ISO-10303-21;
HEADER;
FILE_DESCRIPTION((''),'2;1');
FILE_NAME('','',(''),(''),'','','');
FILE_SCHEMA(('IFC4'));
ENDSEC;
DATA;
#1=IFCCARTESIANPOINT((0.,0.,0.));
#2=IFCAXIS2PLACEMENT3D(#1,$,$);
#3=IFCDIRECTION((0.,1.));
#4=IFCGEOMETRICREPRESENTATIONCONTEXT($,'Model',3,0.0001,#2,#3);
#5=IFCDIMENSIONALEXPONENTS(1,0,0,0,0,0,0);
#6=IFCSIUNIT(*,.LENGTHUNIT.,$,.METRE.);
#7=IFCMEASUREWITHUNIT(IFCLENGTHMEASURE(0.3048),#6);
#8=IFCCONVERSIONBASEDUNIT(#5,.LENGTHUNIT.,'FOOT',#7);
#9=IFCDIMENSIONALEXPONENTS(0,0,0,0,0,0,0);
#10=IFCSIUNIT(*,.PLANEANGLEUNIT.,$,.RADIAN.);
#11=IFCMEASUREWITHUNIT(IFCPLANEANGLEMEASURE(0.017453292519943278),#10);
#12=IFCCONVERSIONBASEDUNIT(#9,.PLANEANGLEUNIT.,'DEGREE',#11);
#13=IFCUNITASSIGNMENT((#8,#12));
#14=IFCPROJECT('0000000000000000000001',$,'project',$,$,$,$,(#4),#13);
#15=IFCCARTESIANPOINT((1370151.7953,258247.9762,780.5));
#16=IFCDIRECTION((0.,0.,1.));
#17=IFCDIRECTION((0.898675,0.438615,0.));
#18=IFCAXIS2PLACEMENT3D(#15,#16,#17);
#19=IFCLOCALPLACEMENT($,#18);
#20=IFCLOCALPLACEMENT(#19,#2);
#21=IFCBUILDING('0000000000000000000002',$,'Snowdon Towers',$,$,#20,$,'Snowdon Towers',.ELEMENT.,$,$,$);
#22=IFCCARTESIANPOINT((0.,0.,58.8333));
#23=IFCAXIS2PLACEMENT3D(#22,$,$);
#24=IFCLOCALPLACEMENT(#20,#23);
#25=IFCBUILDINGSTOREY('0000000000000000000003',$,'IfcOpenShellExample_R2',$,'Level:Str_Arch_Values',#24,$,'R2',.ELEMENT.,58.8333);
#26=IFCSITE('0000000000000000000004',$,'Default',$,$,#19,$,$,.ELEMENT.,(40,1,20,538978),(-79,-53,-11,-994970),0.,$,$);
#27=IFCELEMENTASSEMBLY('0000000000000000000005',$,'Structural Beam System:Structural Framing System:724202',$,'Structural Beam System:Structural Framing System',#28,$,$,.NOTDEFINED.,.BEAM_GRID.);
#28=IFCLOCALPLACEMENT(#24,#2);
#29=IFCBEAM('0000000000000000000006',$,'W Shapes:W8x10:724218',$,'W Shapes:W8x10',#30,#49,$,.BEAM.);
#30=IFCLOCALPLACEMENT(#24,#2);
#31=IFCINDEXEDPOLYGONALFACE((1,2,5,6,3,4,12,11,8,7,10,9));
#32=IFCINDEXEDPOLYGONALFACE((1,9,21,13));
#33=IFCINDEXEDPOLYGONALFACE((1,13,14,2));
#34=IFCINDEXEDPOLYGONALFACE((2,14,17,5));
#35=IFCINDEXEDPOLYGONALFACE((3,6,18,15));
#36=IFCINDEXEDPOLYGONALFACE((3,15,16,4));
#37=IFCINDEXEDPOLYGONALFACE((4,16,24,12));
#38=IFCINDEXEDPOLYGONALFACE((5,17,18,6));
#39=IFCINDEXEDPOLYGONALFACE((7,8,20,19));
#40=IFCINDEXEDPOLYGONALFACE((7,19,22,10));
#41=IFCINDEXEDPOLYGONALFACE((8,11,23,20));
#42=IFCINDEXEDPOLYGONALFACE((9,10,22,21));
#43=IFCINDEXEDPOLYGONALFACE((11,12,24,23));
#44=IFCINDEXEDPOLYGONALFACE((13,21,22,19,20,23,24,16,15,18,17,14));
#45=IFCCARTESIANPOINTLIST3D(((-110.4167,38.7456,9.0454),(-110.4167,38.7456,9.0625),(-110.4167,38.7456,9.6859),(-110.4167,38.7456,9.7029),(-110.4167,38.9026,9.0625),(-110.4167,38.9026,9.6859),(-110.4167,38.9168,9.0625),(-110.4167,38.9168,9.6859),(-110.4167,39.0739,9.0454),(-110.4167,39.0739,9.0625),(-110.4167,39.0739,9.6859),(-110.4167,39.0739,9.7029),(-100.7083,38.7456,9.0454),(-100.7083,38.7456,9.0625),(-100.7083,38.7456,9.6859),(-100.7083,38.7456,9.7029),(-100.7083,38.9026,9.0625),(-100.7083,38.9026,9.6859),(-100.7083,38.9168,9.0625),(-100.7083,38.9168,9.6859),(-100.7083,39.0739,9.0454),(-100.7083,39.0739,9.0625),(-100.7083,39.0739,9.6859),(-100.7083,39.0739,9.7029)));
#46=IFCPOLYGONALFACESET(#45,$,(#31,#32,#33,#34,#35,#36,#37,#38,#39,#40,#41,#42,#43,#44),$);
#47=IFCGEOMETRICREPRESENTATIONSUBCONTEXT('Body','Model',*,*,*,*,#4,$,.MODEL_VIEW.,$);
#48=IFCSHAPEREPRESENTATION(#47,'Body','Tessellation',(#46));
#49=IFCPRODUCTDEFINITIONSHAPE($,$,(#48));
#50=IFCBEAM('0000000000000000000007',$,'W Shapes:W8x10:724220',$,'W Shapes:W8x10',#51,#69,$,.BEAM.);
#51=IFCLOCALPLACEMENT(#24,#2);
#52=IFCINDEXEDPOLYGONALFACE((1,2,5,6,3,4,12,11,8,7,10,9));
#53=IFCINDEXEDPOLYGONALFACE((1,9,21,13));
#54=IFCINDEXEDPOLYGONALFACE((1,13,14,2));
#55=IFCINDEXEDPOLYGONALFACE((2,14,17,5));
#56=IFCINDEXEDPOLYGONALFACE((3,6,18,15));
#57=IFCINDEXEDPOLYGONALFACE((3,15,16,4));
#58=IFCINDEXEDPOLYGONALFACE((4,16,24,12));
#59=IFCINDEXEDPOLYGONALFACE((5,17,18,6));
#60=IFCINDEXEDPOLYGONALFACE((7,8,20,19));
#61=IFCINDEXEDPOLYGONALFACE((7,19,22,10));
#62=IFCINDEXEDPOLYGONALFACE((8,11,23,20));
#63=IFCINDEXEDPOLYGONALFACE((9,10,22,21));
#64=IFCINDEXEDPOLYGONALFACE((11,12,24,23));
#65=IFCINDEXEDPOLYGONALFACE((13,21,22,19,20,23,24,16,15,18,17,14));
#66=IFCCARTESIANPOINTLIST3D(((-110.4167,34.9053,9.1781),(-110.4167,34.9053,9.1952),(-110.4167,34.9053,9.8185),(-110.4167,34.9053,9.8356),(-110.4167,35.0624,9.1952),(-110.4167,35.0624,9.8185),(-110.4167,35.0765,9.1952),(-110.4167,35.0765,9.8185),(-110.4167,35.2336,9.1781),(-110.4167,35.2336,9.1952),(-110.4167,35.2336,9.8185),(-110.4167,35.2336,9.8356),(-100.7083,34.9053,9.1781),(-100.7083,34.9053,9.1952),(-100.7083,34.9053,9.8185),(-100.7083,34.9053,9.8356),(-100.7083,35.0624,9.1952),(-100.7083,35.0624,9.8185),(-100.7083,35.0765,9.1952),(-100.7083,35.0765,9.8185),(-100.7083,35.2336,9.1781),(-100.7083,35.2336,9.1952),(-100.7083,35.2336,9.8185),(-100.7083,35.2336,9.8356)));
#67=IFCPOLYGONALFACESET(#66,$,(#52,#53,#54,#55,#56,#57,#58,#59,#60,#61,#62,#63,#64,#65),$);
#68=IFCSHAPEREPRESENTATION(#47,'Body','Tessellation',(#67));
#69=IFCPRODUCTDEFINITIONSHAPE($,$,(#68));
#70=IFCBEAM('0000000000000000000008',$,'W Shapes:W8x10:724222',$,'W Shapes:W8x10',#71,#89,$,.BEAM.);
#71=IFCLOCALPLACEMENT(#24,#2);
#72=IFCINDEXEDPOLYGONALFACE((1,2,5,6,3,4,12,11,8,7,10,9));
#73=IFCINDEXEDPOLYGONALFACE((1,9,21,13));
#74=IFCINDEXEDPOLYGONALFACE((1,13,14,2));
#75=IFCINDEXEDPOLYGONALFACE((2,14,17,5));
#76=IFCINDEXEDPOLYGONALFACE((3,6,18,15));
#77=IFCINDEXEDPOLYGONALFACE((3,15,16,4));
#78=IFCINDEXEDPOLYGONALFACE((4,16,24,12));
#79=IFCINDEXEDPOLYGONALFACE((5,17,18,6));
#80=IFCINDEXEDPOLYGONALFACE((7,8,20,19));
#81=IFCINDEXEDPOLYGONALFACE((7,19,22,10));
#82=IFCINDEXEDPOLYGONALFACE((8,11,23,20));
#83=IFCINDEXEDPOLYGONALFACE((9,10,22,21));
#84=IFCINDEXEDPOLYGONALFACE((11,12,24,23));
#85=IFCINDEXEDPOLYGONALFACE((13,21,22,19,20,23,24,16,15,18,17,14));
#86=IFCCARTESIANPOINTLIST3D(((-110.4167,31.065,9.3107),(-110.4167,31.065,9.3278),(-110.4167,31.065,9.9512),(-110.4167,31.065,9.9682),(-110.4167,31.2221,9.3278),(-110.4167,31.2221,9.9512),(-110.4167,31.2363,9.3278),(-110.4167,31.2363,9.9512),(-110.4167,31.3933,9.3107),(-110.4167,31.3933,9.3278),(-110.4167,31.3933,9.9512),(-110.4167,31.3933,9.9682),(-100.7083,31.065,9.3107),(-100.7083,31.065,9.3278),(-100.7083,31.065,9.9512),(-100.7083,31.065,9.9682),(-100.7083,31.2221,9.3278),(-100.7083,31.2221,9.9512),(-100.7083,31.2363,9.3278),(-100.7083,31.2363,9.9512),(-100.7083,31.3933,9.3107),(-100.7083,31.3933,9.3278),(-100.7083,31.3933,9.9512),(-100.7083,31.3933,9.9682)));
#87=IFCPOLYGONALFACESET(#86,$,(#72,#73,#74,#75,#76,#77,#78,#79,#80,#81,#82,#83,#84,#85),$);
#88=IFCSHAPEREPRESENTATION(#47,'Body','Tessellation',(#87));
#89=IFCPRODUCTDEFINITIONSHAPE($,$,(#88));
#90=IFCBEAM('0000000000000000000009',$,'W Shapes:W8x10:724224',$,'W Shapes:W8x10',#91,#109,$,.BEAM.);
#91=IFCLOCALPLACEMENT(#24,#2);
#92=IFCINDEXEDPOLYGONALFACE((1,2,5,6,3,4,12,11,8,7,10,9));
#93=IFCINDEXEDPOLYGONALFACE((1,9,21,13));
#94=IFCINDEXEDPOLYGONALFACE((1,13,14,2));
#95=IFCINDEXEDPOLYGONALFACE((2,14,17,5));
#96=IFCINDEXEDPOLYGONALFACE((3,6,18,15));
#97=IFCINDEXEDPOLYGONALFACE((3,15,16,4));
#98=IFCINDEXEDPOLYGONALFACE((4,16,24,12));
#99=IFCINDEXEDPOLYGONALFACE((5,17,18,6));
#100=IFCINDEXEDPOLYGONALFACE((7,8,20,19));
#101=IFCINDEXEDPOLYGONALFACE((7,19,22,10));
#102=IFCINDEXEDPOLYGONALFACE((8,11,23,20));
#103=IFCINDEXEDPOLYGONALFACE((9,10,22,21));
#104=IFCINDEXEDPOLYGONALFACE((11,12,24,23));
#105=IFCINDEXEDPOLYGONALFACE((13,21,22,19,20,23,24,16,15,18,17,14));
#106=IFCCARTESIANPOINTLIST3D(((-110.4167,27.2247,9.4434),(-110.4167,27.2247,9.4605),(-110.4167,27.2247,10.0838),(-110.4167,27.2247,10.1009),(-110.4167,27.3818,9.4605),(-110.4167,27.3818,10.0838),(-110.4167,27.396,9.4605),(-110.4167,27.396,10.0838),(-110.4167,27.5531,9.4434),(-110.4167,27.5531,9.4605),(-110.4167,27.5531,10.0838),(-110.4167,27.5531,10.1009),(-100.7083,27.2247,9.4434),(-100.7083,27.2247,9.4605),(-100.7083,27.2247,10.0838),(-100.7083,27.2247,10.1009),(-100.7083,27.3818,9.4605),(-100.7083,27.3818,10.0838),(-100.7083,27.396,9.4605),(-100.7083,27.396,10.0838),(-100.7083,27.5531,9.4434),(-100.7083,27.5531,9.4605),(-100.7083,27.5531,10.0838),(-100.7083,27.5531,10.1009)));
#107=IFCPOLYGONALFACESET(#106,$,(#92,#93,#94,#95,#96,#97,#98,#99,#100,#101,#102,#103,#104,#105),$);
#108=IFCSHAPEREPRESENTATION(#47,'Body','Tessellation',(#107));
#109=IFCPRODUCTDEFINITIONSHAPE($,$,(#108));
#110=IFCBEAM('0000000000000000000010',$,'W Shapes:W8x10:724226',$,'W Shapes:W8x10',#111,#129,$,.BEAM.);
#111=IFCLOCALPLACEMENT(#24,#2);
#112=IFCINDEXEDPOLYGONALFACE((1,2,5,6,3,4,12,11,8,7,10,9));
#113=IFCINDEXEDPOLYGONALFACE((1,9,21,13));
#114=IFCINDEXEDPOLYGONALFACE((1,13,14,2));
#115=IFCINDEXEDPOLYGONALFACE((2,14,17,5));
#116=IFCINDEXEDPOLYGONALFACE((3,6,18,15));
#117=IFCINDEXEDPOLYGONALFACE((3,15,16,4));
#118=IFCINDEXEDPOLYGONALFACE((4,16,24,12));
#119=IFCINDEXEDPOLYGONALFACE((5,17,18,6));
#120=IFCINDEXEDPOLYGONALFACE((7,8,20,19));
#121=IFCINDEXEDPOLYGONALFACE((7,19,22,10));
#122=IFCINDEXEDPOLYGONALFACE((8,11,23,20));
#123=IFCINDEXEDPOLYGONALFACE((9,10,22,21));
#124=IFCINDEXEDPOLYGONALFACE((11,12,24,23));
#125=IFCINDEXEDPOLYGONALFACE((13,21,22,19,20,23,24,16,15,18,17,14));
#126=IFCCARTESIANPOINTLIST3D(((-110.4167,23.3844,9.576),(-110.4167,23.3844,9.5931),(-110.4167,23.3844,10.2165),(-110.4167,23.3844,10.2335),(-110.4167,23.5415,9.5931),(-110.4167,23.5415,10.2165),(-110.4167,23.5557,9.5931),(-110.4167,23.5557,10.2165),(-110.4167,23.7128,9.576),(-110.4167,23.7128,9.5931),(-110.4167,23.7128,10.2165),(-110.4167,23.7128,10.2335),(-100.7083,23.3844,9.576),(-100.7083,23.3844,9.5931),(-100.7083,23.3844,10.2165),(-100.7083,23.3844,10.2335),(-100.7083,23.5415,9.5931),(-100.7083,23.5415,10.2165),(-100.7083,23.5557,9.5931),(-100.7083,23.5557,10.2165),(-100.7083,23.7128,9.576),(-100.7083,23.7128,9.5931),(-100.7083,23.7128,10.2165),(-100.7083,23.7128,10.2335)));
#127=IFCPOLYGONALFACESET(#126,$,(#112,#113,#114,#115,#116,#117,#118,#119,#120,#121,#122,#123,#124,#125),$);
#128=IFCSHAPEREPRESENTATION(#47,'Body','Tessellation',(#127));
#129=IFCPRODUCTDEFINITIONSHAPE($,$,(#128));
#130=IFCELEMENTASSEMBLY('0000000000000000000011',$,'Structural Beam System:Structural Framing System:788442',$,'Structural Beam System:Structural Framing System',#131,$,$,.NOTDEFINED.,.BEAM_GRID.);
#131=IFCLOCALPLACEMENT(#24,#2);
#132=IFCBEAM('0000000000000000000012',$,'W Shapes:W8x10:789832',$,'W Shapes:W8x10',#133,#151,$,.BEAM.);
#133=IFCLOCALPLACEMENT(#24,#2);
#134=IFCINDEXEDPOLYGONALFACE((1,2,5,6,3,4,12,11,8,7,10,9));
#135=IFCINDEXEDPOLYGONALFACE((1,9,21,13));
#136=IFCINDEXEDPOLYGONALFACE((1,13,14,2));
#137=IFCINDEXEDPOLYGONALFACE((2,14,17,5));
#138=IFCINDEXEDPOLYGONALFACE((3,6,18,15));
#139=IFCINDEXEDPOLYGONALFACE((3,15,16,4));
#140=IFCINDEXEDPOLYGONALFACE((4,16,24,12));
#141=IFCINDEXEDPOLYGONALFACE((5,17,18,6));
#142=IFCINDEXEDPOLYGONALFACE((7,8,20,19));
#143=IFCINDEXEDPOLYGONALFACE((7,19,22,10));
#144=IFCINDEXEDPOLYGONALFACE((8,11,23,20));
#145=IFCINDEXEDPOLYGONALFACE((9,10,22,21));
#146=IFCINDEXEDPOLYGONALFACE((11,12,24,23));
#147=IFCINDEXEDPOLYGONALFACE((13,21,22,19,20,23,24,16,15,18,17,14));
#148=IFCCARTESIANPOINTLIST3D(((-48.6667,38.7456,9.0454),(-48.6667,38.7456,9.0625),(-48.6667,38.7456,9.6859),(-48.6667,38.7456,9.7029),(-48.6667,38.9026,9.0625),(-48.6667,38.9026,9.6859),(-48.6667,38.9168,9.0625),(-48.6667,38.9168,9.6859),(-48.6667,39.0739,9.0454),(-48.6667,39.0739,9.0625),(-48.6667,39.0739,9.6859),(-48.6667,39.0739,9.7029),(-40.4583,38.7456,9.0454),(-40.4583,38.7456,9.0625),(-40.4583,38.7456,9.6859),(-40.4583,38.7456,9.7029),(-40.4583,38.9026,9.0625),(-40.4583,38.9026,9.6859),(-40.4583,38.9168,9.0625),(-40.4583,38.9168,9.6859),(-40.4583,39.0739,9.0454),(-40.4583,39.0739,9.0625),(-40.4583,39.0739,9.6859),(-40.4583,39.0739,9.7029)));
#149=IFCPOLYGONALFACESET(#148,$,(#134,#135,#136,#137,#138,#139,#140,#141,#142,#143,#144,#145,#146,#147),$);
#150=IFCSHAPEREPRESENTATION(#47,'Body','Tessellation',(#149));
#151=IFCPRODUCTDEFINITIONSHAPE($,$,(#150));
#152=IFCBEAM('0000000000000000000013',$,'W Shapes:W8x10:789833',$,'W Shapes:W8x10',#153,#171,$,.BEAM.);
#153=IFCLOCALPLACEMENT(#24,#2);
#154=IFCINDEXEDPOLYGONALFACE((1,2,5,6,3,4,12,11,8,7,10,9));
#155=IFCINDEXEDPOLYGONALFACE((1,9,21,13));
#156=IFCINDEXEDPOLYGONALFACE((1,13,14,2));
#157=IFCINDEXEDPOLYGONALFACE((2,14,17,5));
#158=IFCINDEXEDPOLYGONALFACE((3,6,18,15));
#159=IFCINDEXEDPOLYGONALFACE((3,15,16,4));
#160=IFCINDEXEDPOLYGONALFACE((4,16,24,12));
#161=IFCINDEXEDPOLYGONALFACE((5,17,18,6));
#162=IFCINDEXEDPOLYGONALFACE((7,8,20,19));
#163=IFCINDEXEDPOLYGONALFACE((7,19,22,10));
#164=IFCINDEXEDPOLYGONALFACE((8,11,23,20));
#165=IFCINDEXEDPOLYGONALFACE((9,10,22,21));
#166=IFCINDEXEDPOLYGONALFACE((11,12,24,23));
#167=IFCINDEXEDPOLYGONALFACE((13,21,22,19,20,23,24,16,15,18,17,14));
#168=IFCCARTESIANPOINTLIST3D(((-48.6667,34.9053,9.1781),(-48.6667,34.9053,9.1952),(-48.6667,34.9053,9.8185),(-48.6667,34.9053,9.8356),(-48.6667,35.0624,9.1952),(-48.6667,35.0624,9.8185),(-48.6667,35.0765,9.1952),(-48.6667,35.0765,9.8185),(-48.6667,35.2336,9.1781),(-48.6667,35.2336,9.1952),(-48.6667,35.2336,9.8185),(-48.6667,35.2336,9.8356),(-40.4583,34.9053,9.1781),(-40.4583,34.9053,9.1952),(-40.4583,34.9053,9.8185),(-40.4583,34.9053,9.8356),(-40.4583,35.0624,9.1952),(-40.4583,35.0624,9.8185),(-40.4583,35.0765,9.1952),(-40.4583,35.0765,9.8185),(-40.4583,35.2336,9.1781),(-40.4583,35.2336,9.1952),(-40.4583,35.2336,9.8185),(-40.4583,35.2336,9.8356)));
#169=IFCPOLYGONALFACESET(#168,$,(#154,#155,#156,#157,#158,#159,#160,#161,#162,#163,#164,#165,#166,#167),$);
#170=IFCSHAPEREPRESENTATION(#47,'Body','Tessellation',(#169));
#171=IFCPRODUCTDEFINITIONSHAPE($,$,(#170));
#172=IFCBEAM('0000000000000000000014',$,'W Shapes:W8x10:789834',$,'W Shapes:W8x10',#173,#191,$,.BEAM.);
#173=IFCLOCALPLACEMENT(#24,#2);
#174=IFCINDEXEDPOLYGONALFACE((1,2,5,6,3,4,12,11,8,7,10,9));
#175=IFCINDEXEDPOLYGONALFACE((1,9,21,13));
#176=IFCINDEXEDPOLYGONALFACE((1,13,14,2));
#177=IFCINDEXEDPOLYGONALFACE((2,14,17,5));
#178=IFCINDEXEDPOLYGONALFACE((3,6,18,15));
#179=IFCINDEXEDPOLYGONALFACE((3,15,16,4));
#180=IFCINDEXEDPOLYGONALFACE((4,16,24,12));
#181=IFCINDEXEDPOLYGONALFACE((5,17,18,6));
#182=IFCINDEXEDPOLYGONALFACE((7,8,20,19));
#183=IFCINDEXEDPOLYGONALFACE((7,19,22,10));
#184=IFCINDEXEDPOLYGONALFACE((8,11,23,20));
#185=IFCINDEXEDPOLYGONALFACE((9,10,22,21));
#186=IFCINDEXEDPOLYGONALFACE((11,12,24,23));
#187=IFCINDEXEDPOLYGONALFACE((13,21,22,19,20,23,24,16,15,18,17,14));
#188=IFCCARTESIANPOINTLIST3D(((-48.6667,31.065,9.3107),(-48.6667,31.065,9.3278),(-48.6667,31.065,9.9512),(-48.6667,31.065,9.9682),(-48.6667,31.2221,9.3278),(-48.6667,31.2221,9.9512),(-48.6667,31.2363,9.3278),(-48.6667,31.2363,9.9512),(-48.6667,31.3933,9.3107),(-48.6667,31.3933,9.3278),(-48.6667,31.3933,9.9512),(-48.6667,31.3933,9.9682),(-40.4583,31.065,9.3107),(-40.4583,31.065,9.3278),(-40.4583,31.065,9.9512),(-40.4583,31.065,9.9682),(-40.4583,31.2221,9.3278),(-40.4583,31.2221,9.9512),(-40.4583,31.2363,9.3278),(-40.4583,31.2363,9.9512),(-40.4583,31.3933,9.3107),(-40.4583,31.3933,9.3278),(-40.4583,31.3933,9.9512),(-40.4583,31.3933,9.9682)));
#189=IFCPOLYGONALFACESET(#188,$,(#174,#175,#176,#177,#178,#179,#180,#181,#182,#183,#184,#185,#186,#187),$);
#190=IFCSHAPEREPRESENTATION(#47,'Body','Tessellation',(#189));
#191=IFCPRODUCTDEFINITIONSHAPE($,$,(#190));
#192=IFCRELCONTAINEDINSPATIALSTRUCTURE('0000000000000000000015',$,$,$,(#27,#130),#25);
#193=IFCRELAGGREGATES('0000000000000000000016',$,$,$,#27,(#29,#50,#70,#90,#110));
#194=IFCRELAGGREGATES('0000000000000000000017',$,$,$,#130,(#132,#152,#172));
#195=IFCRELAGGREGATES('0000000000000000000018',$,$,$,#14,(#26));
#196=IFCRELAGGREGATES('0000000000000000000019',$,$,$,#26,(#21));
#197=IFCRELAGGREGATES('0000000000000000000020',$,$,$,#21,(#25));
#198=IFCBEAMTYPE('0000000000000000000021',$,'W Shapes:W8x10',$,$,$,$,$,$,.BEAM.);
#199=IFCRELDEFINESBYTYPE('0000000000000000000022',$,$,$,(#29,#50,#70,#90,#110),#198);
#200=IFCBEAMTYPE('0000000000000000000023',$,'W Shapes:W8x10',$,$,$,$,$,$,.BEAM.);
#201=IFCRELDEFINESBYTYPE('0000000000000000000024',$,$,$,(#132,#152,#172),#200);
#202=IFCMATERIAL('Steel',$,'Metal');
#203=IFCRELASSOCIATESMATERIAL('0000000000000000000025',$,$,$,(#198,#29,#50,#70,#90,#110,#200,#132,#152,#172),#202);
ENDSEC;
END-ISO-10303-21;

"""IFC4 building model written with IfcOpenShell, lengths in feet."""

from ifc_helpers import new_model, entity, si_unit, converted_unit, direction, frame, origin, place, context, subcontext, project, spatial, indexed_curve, outline, extrude, source, transform, mapped, material, type_object, type_shapes, element, aggregate, save


model = new_model("IFC4")

# Units and contexts
model_context = context("Model", 3, precision=0.0001, world=origin(), true_north=direction((0.0, 1.0)))
body_context = subcontext(model_context, "Body", "Model", "MODEL_VIEW")
ifc_project = project(units=[converted_unit("LENGTHUNIT", "FOOT", entity("IfcLengthMeasure", 0.3048), si_unit("LENGTHUNIT", "METRE"), dimensions=[1, 0, 0, 0, 0, 0, 0]), converted_unit("PLANEANGLEUNIT", "DEGREE", entity("IfcPlaneAngleMeasure", 0.017453292519943278), si_unit("PLANEANGLEUNIT", "RADIAN"), dimensions=[0, 0, 0, 0, 0, 0, 0])], contexts=[model_context])

# Site, building, storey
site_placement = place(None, frame((1370151.7953, 258247.9762, 780.5), z_axis=(0.0, 0.0, 1.0), x_axis=(0.898675, 0.438615, 0.0)))
site = spatial("IfcSite", under=ifc_project, at=site_placement, Name="Default", CompositionType="ELEMENT", RefLatitude=(40, 1, 20, 538978), RefLongitude=(-79, -53, -11, -994970), RefElevation=0.0)
building_placement = place(site_placement, origin())
building = spatial("IfcBuilding", under=site, at=building_placement, Name="Snowdon Towers", LongName="Snowdon Towers", CompositionType="ELEMENT")
storey_placement = place(building_placement, frame((0.0, 0.0, 58.8333)))
storey = spatial("IfcBuildingStorey", under=building, at=storey_placement, Name="IfcOpenShellExample_R2", ObjectType="Level:Str_Arch_Values", LongName="R2", CompositionType="ELEMENT", Elevation=58.8333)

# Element assemblies, beams
assembly_1_placement = place(storey_placement, origin())
assembly_1 = element("IfcElementAssembly", 1, at=assembly_1_placement, inside=storey, Name="Structural Beam System:Structural Framing System:724202", ObjectType="Structural Beam System:Structural Framing System", AssemblyPlace="NOTDEFINED", PredefinedType="BEAM_GRID")
ifc_material_1 = material(Name="Steel", Category="Metal")
beam_type_1 = type_object("IfcBeamType", Name="W Shapes:W8x10", PredefinedType="BEAM", material=ifc_material_1)
shared_shape_1 = source(origin(), body_context, "Body", "SweptSolid", [
    extrude(outline(indexed_curve([(-0.1642, -0.3117), (-0.1642, -0.3288), (0.1642, -0.3288), (0.1642, -0.3117), (0.0071, -0.3117), (0.0071, 0.3117), (0.1642, 0.3117), (0.1642, 0.3287), (-0.1642, 0.3287), (-0.1642, 0.3117), (-0.0071, 0.3117), (-0.0071, -0.3117), (-0.1642, -0.3117)], self_intersect=False)), frame((-4.8542, 0.0, 0.0), z_axis=(-1.0, 0.0, 0.0), x_axis=(0.0, -1.0, 0.0)), (0.0, 0.0, -1.0), 9.7083),
])
type_shapes(beam_type_1, [shared_shape_1])
beam_1_placement = place(assembly_1_placement, frame((-105.5625, 38.9097, 9.3742)))
beam_1 = element("IfcBeam", 2, at=beam_1_placement, type_object=beam_type_1, material=ifc_material_1, Name="W Shapes:W8x10:724218", ObjectType="W Shapes:W8x10", PredefinedType="BEAM", context=body_context, shape_type="MappedRepresentation", body=[
    mapped(shared_shape_1, transform((0.0, 0.0, 0.0), scale=1.0)),
])
beam_2_placement = place(assembly_1_placement, frame((-105.5625, 35.0694, 9.5068)))
beam_2 = element("IfcBeam", 3, at=beam_2_placement, type_object=beam_type_1, material=ifc_material_1, Name="W Shapes:W8x10:724220", ObjectType="W Shapes:W8x10", PredefinedType="BEAM", context=body_context, shape_type="MappedRepresentation", body=[
    mapped(shared_shape_1, transform((0.0, 0.0, 0.0), scale=1.0)),
])
beam_3_placement = place(assembly_1_placement, frame((-105.5625, 31.2292, 9.6395)))
beam_3 = element("IfcBeam", 4, at=beam_3_placement, type_object=beam_type_1, material=ifc_material_1, Name="W Shapes:W8x10:724222", ObjectType="W Shapes:W8x10", PredefinedType="BEAM", context=body_context, shape_type="MappedRepresentation", body=[
    mapped(shared_shape_1, transform((0.0, 0.0, 0.0), scale=1.0)),
])
beam_4_placement = place(assembly_1_placement, frame((-105.5625, 27.3889, 9.7721)))
beam_4 = element("IfcBeam", 5, at=beam_4_placement, type_object=beam_type_1, material=ifc_material_1, Name="W Shapes:W8x10:724224", ObjectType="W Shapes:W8x10", PredefinedType="BEAM", context=body_context, shape_type="MappedRepresentation", body=[
    mapped(shared_shape_1, transform((0.0, 0.0, 0.0), scale=1.0)),
])
beam_5_placement = place(assembly_1_placement, frame((-105.5625, 23.5486, 9.9048)))
beam_5 = element("IfcBeam", 6, at=beam_5_placement, type_object=beam_type_1, material=ifc_material_1, Name="W Shapes:W8x10:724226", ObjectType="W Shapes:W8x10", PredefinedType="BEAM", context=body_context, shape_type="MappedRepresentation", body=[
    mapped(shared_shape_1, transform((0.0, 0.0, 0.0), scale=1.0)),
])
aggregate(assembly_1, [beam_1, beam_2, beam_3, beam_4, beam_5])
assembly_2_placement = place(storey_placement, origin())
assembly_2 = element("IfcElementAssembly", 7, at=assembly_2_placement, inside=storey, Name="Structural Beam System:Structural Framing System:788442", ObjectType="Structural Beam System:Structural Framing System", AssemblyPlace="NOTDEFINED", PredefinedType="BEAM_GRID")
beam_type_2 = type_object("IfcBeamType", Name="W Shapes:W8x10", PredefinedType="BEAM", material=ifc_material_1)
shared_shape_2 = source(origin(), body_context, "Body", "SweptSolid", [
    extrude(outline(indexed_curve([(-0.1642, -0.3117), (-0.1642, -0.3288), (0.1642, -0.3288), (0.1642, -0.3117), (0.0071, -0.3117), (0.0071, 0.3117), (0.1642, 0.3117), (0.1642, 0.3287), (-0.1642, 0.3287), (-0.1642, 0.3117), (-0.0071, 0.3117), (-0.0071, -0.3117), (-0.1642, -0.3117)], self_intersect=False)), frame((-4.1042, 0.0, 0.0), z_axis=(-1.0, 0.0, 0.0), x_axis=(0.0, -1.0, 0.0)), (0.0, 0.0, -1.0), 8.2083),
])
type_shapes(beam_type_2, [shared_shape_2])
beam_6_placement = place(assembly_2_placement, frame((-44.5625, 38.9097, 9.3742)))
beam_6 = element("IfcBeam", 8, at=beam_6_placement, type_object=beam_type_2, material=ifc_material_1, Name="W Shapes:W8x10:789832", ObjectType="W Shapes:W8x10", PredefinedType="BEAM", context=body_context, shape_type="MappedRepresentation", body=[
    mapped(shared_shape_2, transform((0.0, 0.0, 0.0), scale=1.0)),
])
beam_7_placement = place(assembly_2_placement, frame((-44.5625, 35.0694, 9.5068)))
beam_7 = element("IfcBeam", 9, at=beam_7_placement, type_object=beam_type_2, material=ifc_material_1, Name="W Shapes:W8x10:789833", ObjectType="W Shapes:W8x10", PredefinedType="BEAM", context=body_context, shape_type="MappedRepresentation", body=[
    mapped(shared_shape_2, transform((0.0, 0.0, 0.0), scale=1.0)),
])
beam_8_placement = place(assembly_2_placement, frame((-44.5625, 31.2292, 9.6395)))
beam_8 = element("IfcBeam", 10, at=beam_8_placement, type_object=beam_type_2, material=ifc_material_1, Name="W Shapes:W8x10:789834", ObjectType="W Shapes:W8x10", PredefinedType="BEAM", context=body_context, shape_type="MappedRepresentation", body=[
    mapped(shared_shape_2, transform((0.0, 0.0, 0.0), scale=1.0)),
])
aggregate(assembly_2, [beam_6, beam_7, beam_8])

save(model, "model.ifc")
